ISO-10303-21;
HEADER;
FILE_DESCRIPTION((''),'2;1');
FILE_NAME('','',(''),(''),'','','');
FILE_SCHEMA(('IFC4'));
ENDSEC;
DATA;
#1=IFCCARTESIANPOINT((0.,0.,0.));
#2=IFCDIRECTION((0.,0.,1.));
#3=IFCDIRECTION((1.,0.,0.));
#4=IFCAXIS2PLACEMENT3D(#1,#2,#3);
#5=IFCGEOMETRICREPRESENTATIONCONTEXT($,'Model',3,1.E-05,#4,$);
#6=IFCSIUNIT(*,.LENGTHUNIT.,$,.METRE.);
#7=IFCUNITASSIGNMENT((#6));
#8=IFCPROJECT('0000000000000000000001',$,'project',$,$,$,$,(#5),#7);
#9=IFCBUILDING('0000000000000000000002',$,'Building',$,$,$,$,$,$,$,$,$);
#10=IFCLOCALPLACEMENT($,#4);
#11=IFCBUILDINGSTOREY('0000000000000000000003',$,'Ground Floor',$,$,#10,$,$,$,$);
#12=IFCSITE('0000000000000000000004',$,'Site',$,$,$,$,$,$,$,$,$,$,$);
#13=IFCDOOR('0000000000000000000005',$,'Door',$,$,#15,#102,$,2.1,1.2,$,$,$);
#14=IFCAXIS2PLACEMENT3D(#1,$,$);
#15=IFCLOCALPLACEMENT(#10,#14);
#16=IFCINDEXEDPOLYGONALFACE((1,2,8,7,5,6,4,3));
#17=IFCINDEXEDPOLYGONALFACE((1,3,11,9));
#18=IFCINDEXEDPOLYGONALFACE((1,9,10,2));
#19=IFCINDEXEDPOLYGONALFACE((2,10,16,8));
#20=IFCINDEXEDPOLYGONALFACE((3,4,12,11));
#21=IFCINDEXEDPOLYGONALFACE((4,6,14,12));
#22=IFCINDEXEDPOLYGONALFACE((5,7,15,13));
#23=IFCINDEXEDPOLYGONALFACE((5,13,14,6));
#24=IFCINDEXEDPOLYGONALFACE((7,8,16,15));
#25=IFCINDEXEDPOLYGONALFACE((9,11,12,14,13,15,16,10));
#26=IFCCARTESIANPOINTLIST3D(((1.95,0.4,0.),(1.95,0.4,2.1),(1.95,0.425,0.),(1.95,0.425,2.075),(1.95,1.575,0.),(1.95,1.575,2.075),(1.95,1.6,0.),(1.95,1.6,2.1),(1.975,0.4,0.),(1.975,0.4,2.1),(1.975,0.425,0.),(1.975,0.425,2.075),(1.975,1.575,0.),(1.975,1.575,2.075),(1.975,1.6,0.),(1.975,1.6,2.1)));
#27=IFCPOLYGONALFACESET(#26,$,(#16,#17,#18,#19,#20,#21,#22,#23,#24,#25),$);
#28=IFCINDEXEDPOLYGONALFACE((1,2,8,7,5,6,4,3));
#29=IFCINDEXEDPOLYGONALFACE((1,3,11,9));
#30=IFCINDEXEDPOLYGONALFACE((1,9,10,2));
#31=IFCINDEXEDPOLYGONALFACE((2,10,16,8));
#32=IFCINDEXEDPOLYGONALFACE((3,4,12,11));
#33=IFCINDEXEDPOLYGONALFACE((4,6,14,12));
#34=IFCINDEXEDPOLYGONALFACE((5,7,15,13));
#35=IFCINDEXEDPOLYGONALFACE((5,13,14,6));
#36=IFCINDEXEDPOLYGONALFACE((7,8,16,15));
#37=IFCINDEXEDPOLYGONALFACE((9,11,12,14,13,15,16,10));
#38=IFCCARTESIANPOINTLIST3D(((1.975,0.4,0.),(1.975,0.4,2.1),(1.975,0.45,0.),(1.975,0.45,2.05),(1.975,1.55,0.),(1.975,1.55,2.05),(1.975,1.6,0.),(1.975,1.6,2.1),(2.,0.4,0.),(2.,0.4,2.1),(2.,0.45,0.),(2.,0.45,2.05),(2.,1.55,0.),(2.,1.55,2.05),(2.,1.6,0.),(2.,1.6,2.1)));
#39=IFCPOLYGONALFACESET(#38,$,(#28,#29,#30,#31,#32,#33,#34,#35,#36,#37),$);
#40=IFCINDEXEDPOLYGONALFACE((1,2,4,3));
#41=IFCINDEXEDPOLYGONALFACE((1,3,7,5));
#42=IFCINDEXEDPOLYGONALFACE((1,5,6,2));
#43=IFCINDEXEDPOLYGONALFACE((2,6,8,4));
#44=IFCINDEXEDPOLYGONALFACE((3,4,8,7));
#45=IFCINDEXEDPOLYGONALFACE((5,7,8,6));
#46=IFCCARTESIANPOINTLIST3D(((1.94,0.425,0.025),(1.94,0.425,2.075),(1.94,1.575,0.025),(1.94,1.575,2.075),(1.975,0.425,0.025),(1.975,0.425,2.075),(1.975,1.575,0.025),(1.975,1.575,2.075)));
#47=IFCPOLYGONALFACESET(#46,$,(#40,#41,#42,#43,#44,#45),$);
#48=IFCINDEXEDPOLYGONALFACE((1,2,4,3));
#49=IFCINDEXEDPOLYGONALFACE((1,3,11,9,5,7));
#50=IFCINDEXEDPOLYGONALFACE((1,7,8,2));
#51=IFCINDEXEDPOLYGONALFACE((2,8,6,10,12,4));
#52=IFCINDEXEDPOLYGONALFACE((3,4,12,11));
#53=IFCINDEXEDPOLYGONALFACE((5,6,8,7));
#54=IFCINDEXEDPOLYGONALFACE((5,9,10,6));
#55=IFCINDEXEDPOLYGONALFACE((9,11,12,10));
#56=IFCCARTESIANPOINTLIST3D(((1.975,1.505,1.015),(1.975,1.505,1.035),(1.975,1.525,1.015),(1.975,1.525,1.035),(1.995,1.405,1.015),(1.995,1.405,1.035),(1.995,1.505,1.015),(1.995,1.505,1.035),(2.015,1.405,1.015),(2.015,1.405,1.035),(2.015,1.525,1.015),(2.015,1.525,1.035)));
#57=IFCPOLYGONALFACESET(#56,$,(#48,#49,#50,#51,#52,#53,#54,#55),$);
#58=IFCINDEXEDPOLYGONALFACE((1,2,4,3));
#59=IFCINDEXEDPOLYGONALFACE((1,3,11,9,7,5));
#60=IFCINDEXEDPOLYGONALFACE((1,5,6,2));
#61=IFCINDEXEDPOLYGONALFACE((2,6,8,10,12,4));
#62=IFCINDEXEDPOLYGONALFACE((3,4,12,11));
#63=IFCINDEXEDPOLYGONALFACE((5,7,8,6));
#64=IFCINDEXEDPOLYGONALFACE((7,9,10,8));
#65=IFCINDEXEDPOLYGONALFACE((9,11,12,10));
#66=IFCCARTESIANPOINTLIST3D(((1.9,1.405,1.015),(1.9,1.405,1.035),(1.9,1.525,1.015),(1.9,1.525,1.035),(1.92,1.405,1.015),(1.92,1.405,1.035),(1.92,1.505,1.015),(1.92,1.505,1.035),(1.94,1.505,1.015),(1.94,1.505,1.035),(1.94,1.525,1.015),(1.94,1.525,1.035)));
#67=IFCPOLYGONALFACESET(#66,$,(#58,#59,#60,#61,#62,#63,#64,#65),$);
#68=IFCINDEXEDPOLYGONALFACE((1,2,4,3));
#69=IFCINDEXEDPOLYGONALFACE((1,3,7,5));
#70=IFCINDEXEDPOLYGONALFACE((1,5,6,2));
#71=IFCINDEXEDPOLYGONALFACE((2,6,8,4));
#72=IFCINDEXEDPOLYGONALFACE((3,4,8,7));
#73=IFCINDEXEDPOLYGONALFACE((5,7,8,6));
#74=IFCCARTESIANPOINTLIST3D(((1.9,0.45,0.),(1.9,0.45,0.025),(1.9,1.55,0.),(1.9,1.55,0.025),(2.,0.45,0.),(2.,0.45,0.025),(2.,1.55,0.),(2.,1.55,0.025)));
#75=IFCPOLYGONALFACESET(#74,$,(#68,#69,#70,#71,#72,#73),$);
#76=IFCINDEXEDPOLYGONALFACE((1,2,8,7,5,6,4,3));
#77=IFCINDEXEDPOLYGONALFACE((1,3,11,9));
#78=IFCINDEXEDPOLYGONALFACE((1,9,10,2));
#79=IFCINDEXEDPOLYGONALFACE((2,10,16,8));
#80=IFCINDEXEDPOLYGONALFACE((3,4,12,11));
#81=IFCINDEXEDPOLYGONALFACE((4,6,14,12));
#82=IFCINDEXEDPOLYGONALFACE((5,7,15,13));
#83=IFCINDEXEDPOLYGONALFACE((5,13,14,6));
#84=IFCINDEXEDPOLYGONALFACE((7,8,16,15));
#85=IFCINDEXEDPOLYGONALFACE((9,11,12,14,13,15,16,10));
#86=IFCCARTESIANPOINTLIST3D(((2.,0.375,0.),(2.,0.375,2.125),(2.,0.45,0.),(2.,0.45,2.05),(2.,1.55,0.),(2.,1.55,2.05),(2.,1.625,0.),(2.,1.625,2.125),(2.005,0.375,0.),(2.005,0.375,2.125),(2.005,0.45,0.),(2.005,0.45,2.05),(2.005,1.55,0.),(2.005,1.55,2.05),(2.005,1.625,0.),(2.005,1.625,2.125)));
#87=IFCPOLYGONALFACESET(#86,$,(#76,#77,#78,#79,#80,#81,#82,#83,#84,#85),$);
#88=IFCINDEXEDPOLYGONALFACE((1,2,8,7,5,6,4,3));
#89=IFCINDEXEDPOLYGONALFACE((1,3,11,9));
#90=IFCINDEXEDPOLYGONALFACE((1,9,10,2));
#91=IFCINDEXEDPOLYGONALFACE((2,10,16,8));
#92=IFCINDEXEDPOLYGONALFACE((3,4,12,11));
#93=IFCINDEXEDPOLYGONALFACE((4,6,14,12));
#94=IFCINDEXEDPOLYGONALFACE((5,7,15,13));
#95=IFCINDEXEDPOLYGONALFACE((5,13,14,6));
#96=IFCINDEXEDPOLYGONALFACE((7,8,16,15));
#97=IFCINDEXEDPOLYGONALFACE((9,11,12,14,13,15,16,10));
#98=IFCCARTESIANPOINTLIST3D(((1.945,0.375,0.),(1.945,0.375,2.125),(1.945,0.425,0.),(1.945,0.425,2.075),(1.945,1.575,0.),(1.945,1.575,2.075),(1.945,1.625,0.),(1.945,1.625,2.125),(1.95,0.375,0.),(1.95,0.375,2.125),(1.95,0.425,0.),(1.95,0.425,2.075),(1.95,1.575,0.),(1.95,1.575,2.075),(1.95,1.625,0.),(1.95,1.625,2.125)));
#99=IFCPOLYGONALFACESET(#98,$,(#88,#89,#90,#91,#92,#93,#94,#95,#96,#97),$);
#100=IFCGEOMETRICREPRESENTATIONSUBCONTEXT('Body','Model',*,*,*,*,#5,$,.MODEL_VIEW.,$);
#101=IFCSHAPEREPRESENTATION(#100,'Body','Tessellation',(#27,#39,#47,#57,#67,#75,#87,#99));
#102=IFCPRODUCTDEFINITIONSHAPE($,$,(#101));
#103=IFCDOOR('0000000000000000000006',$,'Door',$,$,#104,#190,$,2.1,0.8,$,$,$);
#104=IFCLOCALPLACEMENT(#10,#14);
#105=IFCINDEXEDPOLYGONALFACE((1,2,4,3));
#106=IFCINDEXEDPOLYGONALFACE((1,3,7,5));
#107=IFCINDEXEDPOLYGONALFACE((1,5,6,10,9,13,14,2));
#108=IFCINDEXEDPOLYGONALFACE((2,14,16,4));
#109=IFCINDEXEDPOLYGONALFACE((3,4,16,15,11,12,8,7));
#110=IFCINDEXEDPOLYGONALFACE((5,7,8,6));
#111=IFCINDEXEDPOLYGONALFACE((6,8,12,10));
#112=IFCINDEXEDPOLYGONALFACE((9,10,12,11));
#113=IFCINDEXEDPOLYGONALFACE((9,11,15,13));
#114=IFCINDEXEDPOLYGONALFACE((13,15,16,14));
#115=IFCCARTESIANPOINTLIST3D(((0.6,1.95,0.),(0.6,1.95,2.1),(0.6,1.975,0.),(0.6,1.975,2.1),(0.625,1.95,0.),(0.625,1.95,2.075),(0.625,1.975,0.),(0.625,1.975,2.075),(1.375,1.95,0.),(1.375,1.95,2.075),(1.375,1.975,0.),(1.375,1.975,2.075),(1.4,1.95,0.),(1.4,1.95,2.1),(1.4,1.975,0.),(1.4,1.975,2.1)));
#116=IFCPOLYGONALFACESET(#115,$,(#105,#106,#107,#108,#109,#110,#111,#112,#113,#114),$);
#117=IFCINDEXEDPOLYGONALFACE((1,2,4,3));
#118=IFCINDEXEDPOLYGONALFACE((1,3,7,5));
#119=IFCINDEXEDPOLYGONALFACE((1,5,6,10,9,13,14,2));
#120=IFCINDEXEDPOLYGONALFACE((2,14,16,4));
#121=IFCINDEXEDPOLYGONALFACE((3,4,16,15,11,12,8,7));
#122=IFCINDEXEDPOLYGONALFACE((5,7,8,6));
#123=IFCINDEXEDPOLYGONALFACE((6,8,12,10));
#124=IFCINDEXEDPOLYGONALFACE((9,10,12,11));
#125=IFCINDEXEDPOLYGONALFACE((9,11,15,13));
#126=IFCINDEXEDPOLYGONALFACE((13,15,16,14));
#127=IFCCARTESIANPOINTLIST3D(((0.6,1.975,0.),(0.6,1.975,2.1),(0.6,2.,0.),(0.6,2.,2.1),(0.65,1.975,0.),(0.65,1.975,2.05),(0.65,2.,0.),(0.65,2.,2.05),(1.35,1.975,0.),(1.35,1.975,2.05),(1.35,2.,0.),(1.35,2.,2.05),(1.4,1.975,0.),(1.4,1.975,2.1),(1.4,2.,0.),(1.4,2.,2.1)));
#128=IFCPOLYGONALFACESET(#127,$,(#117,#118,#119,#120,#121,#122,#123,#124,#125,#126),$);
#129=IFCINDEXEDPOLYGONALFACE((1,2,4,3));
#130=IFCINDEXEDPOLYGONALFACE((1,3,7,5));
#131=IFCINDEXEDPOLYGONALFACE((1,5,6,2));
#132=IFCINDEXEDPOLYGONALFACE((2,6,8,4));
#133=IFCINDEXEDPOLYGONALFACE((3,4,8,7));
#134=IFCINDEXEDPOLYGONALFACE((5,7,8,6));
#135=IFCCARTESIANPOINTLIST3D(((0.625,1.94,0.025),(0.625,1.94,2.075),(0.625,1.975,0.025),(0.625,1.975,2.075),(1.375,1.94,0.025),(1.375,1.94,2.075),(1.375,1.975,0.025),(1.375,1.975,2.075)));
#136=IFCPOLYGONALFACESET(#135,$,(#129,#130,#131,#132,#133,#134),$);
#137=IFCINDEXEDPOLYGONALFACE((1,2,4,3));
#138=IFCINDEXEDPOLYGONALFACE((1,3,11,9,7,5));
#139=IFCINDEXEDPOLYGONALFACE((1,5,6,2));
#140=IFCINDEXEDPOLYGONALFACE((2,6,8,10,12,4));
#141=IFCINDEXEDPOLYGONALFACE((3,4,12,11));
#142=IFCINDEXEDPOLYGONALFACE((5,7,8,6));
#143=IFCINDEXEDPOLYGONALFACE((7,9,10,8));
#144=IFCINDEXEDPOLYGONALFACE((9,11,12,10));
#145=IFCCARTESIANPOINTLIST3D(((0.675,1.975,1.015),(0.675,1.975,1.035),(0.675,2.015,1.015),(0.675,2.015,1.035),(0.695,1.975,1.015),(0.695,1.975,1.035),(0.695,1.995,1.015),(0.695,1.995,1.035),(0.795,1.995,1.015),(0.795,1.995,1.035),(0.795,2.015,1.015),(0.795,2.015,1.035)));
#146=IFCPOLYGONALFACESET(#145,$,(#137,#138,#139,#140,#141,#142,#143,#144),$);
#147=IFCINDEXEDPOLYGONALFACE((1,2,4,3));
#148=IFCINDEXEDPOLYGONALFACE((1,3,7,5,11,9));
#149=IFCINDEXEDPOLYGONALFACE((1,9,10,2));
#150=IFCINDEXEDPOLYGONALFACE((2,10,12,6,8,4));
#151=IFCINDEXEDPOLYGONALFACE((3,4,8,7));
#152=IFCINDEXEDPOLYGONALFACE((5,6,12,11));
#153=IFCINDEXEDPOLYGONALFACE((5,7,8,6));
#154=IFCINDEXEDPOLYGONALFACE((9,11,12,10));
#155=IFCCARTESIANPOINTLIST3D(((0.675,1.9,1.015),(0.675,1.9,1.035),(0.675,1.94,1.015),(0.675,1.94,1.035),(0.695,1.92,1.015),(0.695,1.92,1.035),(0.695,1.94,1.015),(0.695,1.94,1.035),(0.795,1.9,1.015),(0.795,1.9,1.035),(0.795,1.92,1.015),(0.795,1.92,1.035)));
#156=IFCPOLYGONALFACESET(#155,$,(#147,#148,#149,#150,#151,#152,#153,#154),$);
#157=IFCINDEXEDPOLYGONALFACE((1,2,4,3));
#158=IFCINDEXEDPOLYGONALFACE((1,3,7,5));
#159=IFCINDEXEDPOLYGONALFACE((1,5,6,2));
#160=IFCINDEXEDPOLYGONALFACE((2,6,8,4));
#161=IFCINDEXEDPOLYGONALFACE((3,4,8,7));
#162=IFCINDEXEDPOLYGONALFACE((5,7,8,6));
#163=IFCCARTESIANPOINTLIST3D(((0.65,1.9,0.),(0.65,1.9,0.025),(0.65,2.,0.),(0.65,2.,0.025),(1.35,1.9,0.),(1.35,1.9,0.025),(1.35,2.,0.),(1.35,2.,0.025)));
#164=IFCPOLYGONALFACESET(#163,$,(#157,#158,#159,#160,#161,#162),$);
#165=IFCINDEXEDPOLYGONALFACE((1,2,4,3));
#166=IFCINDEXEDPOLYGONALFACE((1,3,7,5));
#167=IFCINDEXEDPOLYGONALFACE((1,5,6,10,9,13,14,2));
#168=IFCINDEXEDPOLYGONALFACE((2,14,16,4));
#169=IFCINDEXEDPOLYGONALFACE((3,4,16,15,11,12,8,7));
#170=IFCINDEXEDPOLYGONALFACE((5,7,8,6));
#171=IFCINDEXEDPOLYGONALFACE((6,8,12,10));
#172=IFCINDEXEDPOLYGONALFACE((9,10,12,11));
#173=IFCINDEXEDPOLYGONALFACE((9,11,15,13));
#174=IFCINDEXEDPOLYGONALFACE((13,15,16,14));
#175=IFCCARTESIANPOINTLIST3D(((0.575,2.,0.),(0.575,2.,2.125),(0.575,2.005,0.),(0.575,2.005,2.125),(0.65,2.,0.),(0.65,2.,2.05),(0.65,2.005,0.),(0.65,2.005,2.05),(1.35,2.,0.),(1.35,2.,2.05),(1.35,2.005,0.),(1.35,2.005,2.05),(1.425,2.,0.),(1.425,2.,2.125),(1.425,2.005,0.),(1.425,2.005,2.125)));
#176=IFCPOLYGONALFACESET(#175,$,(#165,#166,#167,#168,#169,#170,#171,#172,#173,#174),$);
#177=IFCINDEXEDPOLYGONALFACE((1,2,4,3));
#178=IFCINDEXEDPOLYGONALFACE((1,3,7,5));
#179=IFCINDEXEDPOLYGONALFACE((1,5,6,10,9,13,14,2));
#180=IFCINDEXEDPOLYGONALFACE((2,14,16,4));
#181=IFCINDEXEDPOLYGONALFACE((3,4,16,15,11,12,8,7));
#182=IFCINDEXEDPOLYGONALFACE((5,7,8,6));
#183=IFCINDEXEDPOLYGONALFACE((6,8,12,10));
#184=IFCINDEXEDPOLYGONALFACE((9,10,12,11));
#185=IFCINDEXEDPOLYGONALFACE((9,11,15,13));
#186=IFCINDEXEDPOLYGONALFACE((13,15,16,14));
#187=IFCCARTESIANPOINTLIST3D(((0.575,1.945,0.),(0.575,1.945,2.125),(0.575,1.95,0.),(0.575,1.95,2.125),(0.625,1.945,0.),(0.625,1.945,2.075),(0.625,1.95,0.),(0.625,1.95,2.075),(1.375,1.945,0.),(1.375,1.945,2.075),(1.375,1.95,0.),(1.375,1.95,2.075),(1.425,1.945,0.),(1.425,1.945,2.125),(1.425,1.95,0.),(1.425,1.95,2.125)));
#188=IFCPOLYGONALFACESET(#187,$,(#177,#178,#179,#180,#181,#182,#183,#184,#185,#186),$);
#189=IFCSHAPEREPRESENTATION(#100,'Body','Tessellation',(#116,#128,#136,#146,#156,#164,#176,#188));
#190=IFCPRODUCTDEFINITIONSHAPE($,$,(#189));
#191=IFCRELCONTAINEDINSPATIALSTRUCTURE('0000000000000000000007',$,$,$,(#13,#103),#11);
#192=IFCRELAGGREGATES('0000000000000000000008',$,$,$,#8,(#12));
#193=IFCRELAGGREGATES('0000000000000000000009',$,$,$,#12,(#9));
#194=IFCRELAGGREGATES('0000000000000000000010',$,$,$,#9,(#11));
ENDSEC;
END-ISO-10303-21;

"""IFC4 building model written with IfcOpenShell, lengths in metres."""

from ifc_helpers import new_model, si_unit, frame, origin_with_axes, place, context, subcontext, project, spatial, line, indexed_curve, outline, extrude, element, save


model = new_model("IFC4")

# Units and contexts
model_context = context("Model", 3, precision=1e-05, world=origin_with_axes())
body_context = subcontext(model_context, "Body", "Model", "MODEL_VIEW")
ifc_project = project(units=[si_unit("LENGTHUNIT", "METRE")], contexts=[model_context])

# Site, building, storey
site = spatial("IfcSite", under=ifc_project, Name="Site")
building = spatial("IfcBuilding", under=site, Name="Building")
storey_placement = place(None, origin_with_axes())
storey = spatial("IfcBuildingStorey", under=building, at=storey_placement, Name="Ground Floor")

# Doors
door_1_placement = place(storey_placement, frame((2.0, 0.4, 0.0), z_axis=(0.0, 0.0, 1.0), x_axis=(0.0, 1.0, 0.0)))
element("IfcDoor", 1, at=door_1_placement, inside=storey, Name="Door", OverallHeight=2.1, OverallWidth=1.2, context=body_context, shape_type="SweptSolid", body=[
    extrude(outline(indexed_curve([(0.0, 0.0), (0.0, 2.1), (1.2, 2.1), (1.2, 0.0), (1.175, 0.0), (1.175, 2.075), (0.025, 2.075), (0.025, 0.0)], segments=[line(1, 2, 3, 4, 5, 6, 7, 8, 1)])), frame((0.0, 0.025, 0.0), z_axis=(0.0, -1.0, 0.0), x_axis=(1.0, 0.0, 0.0)), (0.0, 0.0, -1.0), 0.025),
    extrude(outline(indexed_curve([(0.0, 0.0), (0.0, 2.1), (1.2, 2.1), (1.2, 0.0), (1.15, 0.0), (1.15, 2.05), (0.05, 2.05), (0.05, 0.0)], segments=[line(1, 2, 3, 4, 5, 6, 7, 8, 1)])), frame((0.0, 0.0, 0.0), z_axis=(0.0, -1.0, 0.0), x_axis=(1.0, 0.0, 0.0)), (0.0, 0.0, -1.0), 0.025),
    extrude(outline(indexed_curve([(0.0, 0.0), (1.15, 0.0), (1.15, 0.035), (0.0, 0.035)], segments=[line(1, 2, 3, 4, 1)])), frame((0.025, 0.025, 0.025), z_axis=(0.0, 0.0, 1.0), x_axis=(1.0, 0.0, 0.0)), (0.0, 0.0, 1.0), 2.05),
    extrude(outline(indexed_curve([(0.0, 0.0), (0.0, -0.04), (-0.12, -0.04), (-0.12, -0.02), (-0.02, -0.02), (-0.02, 0.0)], segments=[line(1, 2, 3, 4, 5, 6, 1)])), frame((1.125, 0.025, 1.015), z_axis=(0.0, 0.0, 1.0), x_axis=(1.0, 0.0, 0.0)), (0.0, 0.0, 1.0), 0.02),
    extrude(outline(indexed_curve([(0.0, 0.0), (0.0, 0.04), (-0.12, 0.04), (-0.12, 0.02), (-0.02, 0.02), (-0.02, 0.0)], segments=[line(1, 2, 3, 4, 5, 6, 1)])), frame((1.125, 0.06, 1.015), z_axis=(0.0, 0.0, 1.0), x_axis=(1.0, 0.0, 0.0)), (0.0, 0.0, 1.0), 0.02),
    extrude(outline(indexed_curve([(0.0, 0.0), (1.1, 0.0), (1.1, 0.1), (0.0, 0.1)], segments=[line(1, 2, 3, 4, 1)])), frame((0.05, 0.0, 0.0), z_axis=(0.0, 0.0, 1.0), x_axis=(1.0, 0.0, 0.0)), (0.0, 0.0, 1.0), 0.025),
    extrude(outline(indexed_curve([(0.0, 0.0), (0.0, 2.125), (1.25, 2.125), (1.25, 0.0), (1.175, 0.0), (1.175, 2.05), (0.075, 2.05), (0.075, 0.0)], segments=[line(1, 2, 3, 4, 5, 6, 7, 8, 1)])), frame((-0.025, -0.005, 0.0), z_axis=(0.0, -1.0, 0.0), x_axis=(1.0, 0.0, 0.0)), (0.0, 0.0, -1.0), 0.005),
    extrude(outline(indexed_curve([(0.0, 0.0), (0.0, 2.125), (1.25, 2.125), (1.25, 0.0), (1.2, 0.0), (1.2, 2.075), (0.05, 2.075), (0.05, 0.0)], segments=[line(1, 2, 3, 4, 5, 6, 7, 8, 1)])), frame((-0.025, 0.05, 0.0), z_axis=(0.0, -1.0, 0.0), x_axis=(1.0, 0.0, 0.0)), (0.0, 0.0, -1.0), 0.005),
])
door_2_placement = place(storey_placement, frame((1.4, 2.0, 0.0), z_axis=(0.0, 0.0, 1.0), x_axis=(-1.0, 0.0, 0.0)))
element("IfcDoor", 2, at=door_2_placement, inside=storey, Name="Door", OverallHeight=2.1, OverallWidth=0.8, context=body_context, shape_type="SweptSolid", body=[
    extrude(outline(indexed_curve([(0.0, 0.0), (0.0, 2.1), (0.8, 2.1), (0.8, 0.0), (0.775, 0.0), (0.775, 2.075), (0.025, 2.075), (0.025, 0.0)], segments=[line(1, 2, 3, 4, 5, 6, 7, 8, 1)])), frame((0.0, 0.025, 0.0), z_axis=(0.0, -1.0, 0.0), x_axis=(1.0, 0.0, 0.0)), (0.0, 0.0, -1.0), 0.025),
    extrude(outline(indexed_curve([(0.0, 0.0), (0.0, 2.1), (0.8, 2.1), (0.8, 0.0), (0.75, 0.0), (0.75, 2.05), (0.05, 2.05), (0.05, 0.0)], segments=[line(1, 2, 3, 4, 5, 6, 7, 8, 1)])), frame((0.0, 0.0, 0.0), z_axis=(0.0, -1.0, 0.0), x_axis=(1.0, 0.0, 0.0)), (0.0, 0.0, -1.0), 0.025),
    extrude(outline(indexed_curve([(0.0, 0.0), (0.75, 0.0), (0.75, 0.035), (0.0, 0.035)], segments=[line(1, 2, 3, 4, 1)])), frame((0.025, 0.025, 0.025), z_axis=(0.0, 0.0, 1.0), x_axis=(1.0, 0.0, 0.0)), (0.0, 0.0, 1.0), 2.05),
    extrude(outline(indexed_curve([(0.0, 0.0), (0.0, -0.04), (-0.12, -0.04), (-0.12, -0.02), (-0.02, -0.02), (-0.02, 0.0)], segments=[line(1, 2, 3, 4, 5, 6, 1)])), frame((0.725, 0.025, 1.015), z_axis=(0.0, 0.0, 1.0), x_axis=(1.0, 0.0, 0.0)), (0.0, 0.0, 1.0), 0.02),
    extrude(outline(indexed_curve([(0.0, 0.0), (0.0, 0.04), (-0.12, 0.04), (-0.12, 0.02), (-0.02, 0.02), (-0.02, 0.0)], segments=[line(1, 2, 3, 4, 5, 6, 1)])), frame((0.725, 0.06, 1.015), z_axis=(0.0, 0.0, 1.0), x_axis=(1.0, 0.0, 0.0)), (0.0, 0.0, 1.0), 0.02),
    extrude(outline(indexed_curve([(0.0, 0.0), (0.7, 0.0), (0.7, 0.1), (0.0, 0.1)], segments=[line(1, 2, 3, 4, 1)])), frame((0.05, 0.0, 0.0), z_axis=(0.0, 0.0, 1.0), x_axis=(1.0, 0.0, 0.0)), (0.0, 0.0, 1.0), 0.025),
    extrude(outline(indexed_curve([(0.0, 0.0), (0.0, 2.125), (0.85, 2.125), (0.85, 0.0), (0.775, 0.0), (0.775, 2.05), (0.075, 2.05), (0.075, 0.0)], segments=[line(1, 2, 3, 4, 5, 6, 7, 8, 1)])), frame((-0.025, -0.005, 0.0), z_axis=(0.0, -1.0, 0.0), x_axis=(1.0, 0.0, 0.0)), (0.0, 0.0, -1.0), 0.005),
    extrude(outline(indexed_curve([(0.0, 0.0), (0.0, 2.125), (0.85, 2.125), (0.85, 0.0), (0.8, 0.0), (0.8, 2.075), (0.05, 2.075), (0.05, 0.0)], segments=[line(1, 2, 3, 4, 5, 6, 7, 8, 1)])), frame((-0.025, 0.05, 0.0), z_axis=(0.0, -1.0, 0.0), x_axis=(1.0, 0.0, 0.0)), (0.0, 0.0, -1.0), 0.005),
])

save(model, "model.ifc")
